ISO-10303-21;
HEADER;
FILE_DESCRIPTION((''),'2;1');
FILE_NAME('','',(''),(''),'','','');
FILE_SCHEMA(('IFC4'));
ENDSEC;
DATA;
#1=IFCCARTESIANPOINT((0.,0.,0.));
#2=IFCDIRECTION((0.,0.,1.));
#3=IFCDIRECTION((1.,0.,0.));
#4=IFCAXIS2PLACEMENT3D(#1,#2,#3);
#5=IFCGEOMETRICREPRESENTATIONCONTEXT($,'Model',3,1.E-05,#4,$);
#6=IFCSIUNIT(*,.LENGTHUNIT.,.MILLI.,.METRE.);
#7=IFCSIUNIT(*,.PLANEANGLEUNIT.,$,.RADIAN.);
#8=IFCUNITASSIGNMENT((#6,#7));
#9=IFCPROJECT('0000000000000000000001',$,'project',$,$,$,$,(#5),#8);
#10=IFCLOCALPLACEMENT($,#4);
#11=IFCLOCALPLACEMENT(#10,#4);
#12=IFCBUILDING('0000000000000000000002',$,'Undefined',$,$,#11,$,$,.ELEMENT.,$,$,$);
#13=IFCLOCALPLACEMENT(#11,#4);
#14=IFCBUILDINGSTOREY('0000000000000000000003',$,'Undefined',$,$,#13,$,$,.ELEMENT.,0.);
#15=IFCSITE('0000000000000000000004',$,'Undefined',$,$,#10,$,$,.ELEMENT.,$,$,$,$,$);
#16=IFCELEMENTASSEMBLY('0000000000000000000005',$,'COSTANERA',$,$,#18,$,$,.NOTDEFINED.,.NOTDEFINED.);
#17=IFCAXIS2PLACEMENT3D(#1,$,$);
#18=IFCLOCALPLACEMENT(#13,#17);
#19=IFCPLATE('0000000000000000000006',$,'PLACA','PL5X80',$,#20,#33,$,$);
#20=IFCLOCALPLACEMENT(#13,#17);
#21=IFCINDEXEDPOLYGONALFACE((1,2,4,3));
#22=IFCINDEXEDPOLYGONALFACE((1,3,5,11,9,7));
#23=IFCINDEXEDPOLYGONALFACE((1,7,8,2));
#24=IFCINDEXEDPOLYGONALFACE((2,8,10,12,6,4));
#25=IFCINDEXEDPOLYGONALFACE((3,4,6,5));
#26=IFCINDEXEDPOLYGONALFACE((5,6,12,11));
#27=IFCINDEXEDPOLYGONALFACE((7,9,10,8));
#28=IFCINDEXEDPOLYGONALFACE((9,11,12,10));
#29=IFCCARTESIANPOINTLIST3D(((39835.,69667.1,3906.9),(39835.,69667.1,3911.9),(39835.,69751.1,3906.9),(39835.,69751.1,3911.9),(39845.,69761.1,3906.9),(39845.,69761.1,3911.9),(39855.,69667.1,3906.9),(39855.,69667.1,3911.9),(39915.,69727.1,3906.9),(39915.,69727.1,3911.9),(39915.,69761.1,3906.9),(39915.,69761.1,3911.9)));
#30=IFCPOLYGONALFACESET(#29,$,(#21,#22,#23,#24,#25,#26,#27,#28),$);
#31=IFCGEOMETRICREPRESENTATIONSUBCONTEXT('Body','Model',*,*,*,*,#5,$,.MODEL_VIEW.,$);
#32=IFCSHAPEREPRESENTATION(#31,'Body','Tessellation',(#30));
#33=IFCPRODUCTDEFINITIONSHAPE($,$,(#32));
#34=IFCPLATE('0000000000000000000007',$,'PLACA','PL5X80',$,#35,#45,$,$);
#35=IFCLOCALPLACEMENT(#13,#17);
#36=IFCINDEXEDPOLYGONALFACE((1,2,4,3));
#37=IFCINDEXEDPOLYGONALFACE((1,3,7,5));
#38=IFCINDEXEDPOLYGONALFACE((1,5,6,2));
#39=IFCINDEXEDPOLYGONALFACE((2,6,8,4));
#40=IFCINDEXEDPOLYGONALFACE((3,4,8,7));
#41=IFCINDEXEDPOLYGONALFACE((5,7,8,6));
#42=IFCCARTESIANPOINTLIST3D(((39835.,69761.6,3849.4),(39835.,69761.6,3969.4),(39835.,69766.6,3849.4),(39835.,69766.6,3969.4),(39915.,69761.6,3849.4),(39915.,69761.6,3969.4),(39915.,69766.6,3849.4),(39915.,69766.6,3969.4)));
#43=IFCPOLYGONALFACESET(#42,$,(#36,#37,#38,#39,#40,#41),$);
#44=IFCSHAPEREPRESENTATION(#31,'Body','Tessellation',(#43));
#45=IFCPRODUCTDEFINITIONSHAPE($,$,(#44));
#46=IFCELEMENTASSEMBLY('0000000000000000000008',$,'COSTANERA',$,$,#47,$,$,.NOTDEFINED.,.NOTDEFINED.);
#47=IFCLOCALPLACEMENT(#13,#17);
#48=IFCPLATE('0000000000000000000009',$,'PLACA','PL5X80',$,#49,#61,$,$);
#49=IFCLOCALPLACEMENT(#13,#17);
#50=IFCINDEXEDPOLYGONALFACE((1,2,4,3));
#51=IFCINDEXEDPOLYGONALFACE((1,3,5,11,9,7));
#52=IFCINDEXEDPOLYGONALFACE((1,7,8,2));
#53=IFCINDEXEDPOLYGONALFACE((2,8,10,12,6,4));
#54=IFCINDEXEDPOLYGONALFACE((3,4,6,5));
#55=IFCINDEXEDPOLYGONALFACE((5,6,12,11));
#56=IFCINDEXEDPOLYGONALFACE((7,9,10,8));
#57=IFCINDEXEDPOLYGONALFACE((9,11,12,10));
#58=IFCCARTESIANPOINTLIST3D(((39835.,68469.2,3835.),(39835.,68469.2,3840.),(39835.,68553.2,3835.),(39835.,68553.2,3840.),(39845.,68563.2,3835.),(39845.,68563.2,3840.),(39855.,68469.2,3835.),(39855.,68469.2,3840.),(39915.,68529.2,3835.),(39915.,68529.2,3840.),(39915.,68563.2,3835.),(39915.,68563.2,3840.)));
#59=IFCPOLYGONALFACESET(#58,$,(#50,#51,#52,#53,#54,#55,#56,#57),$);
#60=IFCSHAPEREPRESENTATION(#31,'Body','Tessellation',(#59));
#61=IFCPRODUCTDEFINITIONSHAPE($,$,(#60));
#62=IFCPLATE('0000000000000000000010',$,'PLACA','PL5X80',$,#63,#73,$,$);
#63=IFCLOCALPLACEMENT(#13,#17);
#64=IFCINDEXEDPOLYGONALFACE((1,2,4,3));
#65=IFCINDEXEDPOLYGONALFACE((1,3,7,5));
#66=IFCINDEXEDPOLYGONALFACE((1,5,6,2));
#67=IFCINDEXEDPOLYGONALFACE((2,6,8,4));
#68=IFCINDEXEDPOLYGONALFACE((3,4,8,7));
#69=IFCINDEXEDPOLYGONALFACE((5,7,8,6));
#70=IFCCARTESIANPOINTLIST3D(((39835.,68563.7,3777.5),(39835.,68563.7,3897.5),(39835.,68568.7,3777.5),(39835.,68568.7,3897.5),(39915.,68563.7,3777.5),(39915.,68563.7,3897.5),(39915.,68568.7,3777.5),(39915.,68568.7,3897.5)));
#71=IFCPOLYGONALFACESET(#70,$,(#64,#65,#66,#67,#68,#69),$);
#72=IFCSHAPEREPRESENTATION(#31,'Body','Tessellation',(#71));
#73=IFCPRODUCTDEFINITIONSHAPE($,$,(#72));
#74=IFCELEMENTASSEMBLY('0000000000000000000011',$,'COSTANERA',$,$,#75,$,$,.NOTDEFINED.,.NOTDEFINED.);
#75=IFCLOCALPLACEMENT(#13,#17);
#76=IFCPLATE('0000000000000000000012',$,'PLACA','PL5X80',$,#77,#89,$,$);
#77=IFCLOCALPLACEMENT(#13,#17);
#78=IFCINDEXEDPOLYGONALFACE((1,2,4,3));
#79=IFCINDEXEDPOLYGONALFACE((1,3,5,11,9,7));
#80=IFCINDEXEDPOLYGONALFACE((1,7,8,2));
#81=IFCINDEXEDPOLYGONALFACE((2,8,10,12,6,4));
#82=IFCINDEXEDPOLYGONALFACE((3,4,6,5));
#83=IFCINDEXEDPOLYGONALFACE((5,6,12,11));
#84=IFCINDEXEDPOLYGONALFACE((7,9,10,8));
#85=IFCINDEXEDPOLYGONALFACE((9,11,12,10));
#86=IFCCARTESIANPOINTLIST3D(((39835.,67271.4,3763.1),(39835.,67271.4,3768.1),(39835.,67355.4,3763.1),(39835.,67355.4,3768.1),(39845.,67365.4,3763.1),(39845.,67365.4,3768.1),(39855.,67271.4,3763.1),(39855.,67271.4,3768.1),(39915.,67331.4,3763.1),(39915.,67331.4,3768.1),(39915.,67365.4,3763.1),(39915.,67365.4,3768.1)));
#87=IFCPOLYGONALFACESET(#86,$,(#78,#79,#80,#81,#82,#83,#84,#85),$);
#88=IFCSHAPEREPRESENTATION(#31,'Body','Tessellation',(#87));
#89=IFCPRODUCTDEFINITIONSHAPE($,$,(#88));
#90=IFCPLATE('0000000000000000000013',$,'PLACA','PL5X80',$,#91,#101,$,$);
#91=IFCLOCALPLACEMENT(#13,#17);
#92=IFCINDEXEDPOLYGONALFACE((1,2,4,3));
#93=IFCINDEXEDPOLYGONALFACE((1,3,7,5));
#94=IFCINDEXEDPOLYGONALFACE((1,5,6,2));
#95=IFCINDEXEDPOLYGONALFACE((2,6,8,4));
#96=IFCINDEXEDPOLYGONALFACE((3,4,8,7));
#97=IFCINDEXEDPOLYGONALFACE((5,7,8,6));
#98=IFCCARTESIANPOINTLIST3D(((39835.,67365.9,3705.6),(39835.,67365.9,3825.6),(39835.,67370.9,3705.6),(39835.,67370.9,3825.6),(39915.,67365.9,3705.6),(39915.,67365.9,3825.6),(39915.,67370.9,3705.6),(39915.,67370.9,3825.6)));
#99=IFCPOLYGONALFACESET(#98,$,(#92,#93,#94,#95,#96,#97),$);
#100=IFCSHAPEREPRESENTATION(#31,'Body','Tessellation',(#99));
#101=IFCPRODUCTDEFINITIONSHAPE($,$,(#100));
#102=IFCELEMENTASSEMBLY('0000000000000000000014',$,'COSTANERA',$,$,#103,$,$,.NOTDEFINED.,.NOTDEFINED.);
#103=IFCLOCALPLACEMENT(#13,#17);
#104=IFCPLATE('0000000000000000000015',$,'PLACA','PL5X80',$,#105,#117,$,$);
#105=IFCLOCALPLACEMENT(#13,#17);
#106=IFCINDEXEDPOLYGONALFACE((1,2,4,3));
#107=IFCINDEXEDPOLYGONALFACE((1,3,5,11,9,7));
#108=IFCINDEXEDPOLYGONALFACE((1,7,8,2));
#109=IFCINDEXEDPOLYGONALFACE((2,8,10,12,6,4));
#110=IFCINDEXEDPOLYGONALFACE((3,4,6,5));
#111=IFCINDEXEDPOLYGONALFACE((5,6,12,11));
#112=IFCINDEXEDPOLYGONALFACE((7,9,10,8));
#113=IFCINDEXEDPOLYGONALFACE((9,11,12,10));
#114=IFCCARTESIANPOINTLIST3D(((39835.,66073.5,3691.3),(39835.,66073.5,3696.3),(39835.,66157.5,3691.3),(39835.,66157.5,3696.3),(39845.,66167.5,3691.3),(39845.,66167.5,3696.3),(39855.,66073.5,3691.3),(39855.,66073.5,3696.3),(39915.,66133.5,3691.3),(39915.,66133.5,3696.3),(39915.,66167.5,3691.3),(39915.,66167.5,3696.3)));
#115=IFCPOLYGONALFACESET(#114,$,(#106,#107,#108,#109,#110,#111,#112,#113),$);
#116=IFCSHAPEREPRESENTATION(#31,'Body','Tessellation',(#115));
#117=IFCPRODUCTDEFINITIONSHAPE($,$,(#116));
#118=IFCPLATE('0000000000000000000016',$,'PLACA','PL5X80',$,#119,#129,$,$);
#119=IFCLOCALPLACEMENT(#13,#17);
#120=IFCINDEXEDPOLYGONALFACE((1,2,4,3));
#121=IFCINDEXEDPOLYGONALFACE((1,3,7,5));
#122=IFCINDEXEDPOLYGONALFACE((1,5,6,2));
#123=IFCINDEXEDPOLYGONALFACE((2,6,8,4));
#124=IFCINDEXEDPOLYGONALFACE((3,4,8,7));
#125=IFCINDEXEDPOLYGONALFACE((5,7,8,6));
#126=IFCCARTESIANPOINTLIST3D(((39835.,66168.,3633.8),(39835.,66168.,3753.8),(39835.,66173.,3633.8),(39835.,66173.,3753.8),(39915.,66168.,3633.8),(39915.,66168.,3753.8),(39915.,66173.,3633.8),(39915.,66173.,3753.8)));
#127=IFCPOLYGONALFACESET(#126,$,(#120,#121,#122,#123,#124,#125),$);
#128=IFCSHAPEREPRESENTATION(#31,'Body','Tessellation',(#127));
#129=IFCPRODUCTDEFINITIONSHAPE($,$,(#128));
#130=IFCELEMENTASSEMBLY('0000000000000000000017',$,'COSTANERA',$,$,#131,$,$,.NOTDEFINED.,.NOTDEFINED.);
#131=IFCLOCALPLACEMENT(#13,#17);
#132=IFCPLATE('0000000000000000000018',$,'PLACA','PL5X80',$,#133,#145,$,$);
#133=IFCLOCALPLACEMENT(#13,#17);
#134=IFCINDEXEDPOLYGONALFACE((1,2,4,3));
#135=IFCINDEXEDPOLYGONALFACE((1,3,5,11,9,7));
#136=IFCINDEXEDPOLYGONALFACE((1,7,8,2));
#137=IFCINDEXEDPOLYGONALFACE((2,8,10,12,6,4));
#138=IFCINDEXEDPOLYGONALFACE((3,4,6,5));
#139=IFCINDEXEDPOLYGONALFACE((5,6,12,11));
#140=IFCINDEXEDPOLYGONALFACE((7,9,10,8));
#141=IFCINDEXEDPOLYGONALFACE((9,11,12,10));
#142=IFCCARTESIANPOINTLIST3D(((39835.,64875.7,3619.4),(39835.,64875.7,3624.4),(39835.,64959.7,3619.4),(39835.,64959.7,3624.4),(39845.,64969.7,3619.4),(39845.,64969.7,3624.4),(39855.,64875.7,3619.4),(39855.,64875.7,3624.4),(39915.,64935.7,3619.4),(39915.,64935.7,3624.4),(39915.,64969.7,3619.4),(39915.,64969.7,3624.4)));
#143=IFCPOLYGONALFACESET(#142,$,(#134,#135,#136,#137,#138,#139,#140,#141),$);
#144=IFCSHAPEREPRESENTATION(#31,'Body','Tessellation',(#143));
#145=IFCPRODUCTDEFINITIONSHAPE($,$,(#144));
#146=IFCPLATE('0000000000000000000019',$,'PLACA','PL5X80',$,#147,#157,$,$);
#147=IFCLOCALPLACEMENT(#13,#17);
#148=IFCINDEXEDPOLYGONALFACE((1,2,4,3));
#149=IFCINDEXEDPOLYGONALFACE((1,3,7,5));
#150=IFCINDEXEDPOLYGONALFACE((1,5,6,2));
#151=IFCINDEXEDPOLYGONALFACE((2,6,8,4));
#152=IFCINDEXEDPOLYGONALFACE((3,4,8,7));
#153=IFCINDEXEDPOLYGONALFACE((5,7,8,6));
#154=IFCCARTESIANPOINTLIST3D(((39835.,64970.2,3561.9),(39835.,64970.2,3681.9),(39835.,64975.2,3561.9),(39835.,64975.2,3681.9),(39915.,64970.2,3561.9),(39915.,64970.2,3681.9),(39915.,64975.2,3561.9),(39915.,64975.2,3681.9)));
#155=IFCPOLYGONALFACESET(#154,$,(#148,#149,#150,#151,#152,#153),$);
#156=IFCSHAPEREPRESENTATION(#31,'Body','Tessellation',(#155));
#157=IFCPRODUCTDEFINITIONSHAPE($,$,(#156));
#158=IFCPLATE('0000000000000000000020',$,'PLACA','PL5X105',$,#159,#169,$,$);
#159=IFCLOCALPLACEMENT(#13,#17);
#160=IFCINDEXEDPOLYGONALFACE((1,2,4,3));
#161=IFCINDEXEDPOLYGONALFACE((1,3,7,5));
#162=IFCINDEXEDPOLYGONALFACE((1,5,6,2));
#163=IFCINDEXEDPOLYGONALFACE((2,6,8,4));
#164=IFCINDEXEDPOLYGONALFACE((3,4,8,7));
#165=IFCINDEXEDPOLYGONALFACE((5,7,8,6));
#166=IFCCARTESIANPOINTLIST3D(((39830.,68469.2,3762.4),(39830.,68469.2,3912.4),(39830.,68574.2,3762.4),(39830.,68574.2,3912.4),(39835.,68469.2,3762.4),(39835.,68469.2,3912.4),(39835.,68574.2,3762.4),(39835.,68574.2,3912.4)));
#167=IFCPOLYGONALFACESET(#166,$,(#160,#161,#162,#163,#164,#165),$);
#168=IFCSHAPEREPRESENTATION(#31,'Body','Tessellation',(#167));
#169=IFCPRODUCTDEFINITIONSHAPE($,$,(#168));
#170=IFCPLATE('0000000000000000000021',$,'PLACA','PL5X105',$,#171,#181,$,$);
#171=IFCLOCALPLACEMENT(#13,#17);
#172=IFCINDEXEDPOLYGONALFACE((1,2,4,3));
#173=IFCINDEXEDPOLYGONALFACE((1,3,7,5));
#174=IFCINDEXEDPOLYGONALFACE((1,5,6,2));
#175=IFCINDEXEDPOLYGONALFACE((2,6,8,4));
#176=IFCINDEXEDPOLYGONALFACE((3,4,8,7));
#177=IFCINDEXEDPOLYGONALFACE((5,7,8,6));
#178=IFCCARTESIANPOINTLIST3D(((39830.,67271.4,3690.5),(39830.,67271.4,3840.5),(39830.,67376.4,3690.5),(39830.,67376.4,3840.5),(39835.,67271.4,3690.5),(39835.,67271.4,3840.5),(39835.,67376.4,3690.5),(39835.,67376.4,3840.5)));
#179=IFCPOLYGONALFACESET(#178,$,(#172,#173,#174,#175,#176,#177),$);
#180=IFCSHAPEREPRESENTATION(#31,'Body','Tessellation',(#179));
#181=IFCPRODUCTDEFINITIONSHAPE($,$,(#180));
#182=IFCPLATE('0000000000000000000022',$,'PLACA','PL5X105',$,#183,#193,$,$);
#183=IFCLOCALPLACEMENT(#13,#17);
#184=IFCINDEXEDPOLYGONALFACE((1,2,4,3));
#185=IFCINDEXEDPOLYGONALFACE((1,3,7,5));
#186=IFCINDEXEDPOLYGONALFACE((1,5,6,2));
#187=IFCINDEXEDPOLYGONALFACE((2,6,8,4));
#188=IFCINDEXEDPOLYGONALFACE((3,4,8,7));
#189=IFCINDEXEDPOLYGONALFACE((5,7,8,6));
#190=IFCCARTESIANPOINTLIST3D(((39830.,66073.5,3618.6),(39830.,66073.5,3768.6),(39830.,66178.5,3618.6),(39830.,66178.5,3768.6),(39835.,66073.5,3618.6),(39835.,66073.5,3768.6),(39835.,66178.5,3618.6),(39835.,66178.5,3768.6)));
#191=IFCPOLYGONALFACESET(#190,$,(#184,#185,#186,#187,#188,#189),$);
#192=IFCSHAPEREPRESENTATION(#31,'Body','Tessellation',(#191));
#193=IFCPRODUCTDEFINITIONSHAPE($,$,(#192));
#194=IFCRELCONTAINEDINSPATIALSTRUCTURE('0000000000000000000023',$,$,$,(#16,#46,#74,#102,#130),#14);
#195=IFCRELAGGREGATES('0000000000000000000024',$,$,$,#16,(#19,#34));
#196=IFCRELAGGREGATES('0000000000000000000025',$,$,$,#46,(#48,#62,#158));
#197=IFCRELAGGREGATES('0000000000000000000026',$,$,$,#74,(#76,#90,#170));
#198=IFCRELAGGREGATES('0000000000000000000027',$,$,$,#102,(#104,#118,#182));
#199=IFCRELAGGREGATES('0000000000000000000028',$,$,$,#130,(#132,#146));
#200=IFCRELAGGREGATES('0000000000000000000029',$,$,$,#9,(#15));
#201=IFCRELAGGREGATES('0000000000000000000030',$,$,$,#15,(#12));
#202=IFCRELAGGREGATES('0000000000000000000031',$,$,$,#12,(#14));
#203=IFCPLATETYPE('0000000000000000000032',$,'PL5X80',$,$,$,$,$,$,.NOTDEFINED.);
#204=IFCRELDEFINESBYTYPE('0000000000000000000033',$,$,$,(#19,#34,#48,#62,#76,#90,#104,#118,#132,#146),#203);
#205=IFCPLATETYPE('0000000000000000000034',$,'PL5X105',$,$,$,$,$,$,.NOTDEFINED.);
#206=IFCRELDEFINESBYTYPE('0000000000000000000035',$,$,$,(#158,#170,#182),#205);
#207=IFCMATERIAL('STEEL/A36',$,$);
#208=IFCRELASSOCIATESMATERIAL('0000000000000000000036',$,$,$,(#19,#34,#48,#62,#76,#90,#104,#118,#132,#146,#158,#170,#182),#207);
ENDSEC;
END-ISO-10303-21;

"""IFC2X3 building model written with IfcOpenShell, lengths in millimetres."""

from ifc_helpers import new_model, si_unit, frame, origin_with_axes, place, context, subcontext, project, spatial, polyline, outline, extrude, material, type_object, element, aggregate, save


model = new_model("IFC2X3")

# Units and contexts
model_context = context("Model", 3, precision=1e-05, world=origin_with_axes())
body_context = subcontext(model_context, "Body", "Model", "MODEL_VIEW")
ifc_project = project(units=[si_unit("LENGTHUNIT", "METRE", prefix="MILLI"), si_unit("PLANEANGLEUNIT", "RADIAN")], contexts=[model_context])

# Site, building, storey
site_placement = place(None, origin_with_axes())
site = spatial("IfcSite", under=ifc_project, at=site_placement, Name="Undefined", CompositionType="ELEMENT")
building_placement = place(site_placement, origin_with_axes())
building = spatial("IfcBuilding", under=site, at=building_placement, Name="Undefined", CompositionType="ELEMENT")
storey_placement = place(building_placement, origin_with_axes())
storey = spatial("IfcBuildingStorey", under=building, at=storey_placement, Name="Undefined", CompositionType="ELEMENT", Elevation=0.0)

# Shared definitions
ifc_material_1 = material(Name="STEEL/A36")

# Element assemblies, plates
assembly_1_placement = place(storey_placement, origin_with_axes())
assembly_1 = element("IfcElementAssembly", 1, at=assembly_1_placement, inside=storey, Name="COSTANERA", AssemblyPlace="NOTDEFINED", PredefinedType="NOTDEFINED")
plate_type_1 = type_object("IfcPlateType", Name="PL5X80", PredefinedType="NOTDEFINED")
plate_1_placement = place(assembly_1_placement, frame((39915.0, 69761.1, 3909.4), z_axis=(0.0, 0.0, 1.0), x_axis=(-1.0, 0.0, 0.0)))
plate_1 = element("IfcPlate", 2, at=plate_1_placement, type_object=plate_type_1, material=ifc_material_1, Name="PLACA", Description="PL5X80", context=body_context, shape_type="SweptSolid", body=[
    extrude(outline(polyline([(0.0, 0.0), (70.0, 0.0), (80.0, 10.0), (80.0, 94.0), (60.0, 94.0), (0.0, 34.0), (0.0, 0.0)])), frame((0.0, 0.0, -2.5), z_axis=(0.0, 0.0, 1.0), x_axis=(1.0, 0.0, 0.0)), (0.0, 0.0, 1.0), 5.0),
])
plate_2_placement = place(assembly_1_placement, frame((39915.0, 69764.1, 3969.4), z_axis=(0.0, -1.0, 0.0), x_axis=(-1.0, 0.0, 0.0)))
plate_2 = element("IfcPlate", 3, at=plate_2_placement, type_object=plate_type_1, material=ifc_material_1, Name="PLACA", Description="PL5X80", context=body_context, shape_type="SweptSolid", body=[
    extrude(outline(polyline([(0.0, 0.0), (80.0, 0.0), (80.0, 120.0), (0.0, 120.0), (0.0, 0.0)])), frame((0.0, 0.0, -2.5), z_axis=(0.0, 0.0, 1.0), x_axis=(1.0, 0.0, 0.0)), (0.0, 0.0, 1.0), 5.0),
])
assembly_2_placement = place(storey_placement, origin_with_axes())
assembly_2 = element("IfcElementAssembly", 4, at=assembly_2_placement, inside=storey, Name="COSTANERA", AssemblyPlace="NOTDEFINED", PredefinedType="NOTDEFINED")
plate_3_placement = place(assembly_2_placement, frame((39915.0, 68563.2, 3837.5), z_axis=(0.0, 0.0, 1.0), x_axis=(-1.0, 0.0, 0.0)))
plate_3 = element("IfcPlate", 5, at=plate_3_placement, type_object=plate_type_1, material=ifc_material_1, Name="PLACA", Description="PL5X80", context=body_context, shape_type="SweptSolid", body=[
    extrude(outline(polyline([(0.0, 0.0), (70.0, 0.0), (80.0, 10.0), (80.0, 94.0), (60.0, 94.0), (0.0, 34.0), (0.0, 0.0)])), frame((0.0, 0.0, -2.5), z_axis=(0.0, 0.0, 1.0), x_axis=(1.0, 0.0, 0.0)), (0.0, 0.0, 1.0), 5.0),
])
plate_4_placement = place(assembly_2_placement, frame((39915.0, 68566.2, 3897.5), z_axis=(0.0, -1.0, 0.0), x_axis=(-1.0, 0.0, 0.0)))
plate_4 = element("IfcPlate", 6, at=plate_4_placement, type_object=plate_type_1, material=ifc_material_1, Name="PLACA", Description="PL5X80", context=body_context, shape_type="SweptSolid", body=[
    extrude(outline(polyline([(0.0, 0.0), (80.0, 0.0), (80.0, 120.0), (0.0, 120.0), (0.0, 0.0)])), frame((0.0, 0.0, -2.5), z_axis=(0.0, 0.0, 1.0), x_axis=(1.0, 0.0, 0.0)), (0.0, 0.0, 1.0), 5.0),
])
assembly_3_placement = place(storey_placement, origin_with_axes())
assembly_3 = element("IfcElementAssembly", 7, at=assembly_3_placement, inside=storey, Name="COSTANERA", AssemblyPlace="NOTDEFINED", PredefinedType="NOTDEFINED")
plate_5_placement = place(assembly_3_placement, frame((39915.0, 67365.4, 3765.6), z_axis=(0.0, 0.0, 1.0), x_axis=(-1.0, 0.0, 0.0)))
plate_5 = element("IfcPlate", 8, at=plate_5_placement, type_object=plate_type_1, material=ifc_material_1, Name="PLACA", Description="PL5X80", context=body_context, shape_type="SweptSolid", body=[
    extrude(outline(polyline([(0.0, 0.0), (70.0, 0.0), (80.0, 10.0), (80.0, 94.0), (60.0, 94.0), (0.0, 34.0), (0.0, 0.0)])), frame((0.0, 0.0, -2.5), z_axis=(0.0, 0.0, 1.0), x_axis=(1.0, 0.0, 0.0)), (0.0, 0.0, 1.0), 5.0),
])
plate_6_placement = place(assembly_3_placement, frame((39915.0, 67368.4, 3825.6), z_axis=(0.0, -1.0, 0.0), x_axis=(-1.0, 0.0, 0.0)))
plate_6 = element("IfcPlate", 9, at=plate_6_placement, type_object=plate_type_1, material=ifc_material_1, Name="PLACA", Description="PL5X80", context=body_context, shape_type="SweptSolid", body=[
    extrude(outline(polyline([(0.0, 0.0), (80.0, 0.0), (80.0, 120.0), (0.0, 120.0), (0.0, 0.0)])), frame((0.0, 0.0, -2.5), z_axis=(0.0, 0.0, 1.0), x_axis=(1.0, 0.0, 0.0)), (0.0, 0.0, 1.0), 5.0),
])
assembly_4_placement = place(storey_placement, origin_with_axes())
assembly_4 = element("IfcElementAssembly", 10, at=assembly_4_placement, inside=storey, Name="COSTANERA", AssemblyPlace="NOTDEFINED", PredefinedType="NOTDEFINED")
plate_7_placement = place(assembly_4_placement, frame((39915.0, 66167.5, 3693.8), z_axis=(0.0, 0.0, 1.0), x_axis=(-1.0, 0.0, 0.0)))
plate_7 = element("IfcPlate", 11, at=plate_7_placement, type_object=plate_type_1, material=ifc_material_1, Name="PLACA", Description="PL5X80", context=body_context, shape_type="SweptSolid", body=[
    extrude(outline(polyline([(0.0, 0.0), (70.0, 0.0), (80.0, 10.0), (80.0, 94.0), (60.0, 94.0), (0.0, 34.0), (0.0, 0.0)])), frame((0.0, 0.0, -2.5), z_axis=(0.0, 0.0, 1.0), x_axis=(1.0, 0.0, 0.0)), (0.0, 0.0, 1.0), 5.0),
])
plate_8_placement = place(assembly_4_placement, frame((39915.0, 66170.5, 3753.8), z_axis=(0.0, -1.0, 0.0), x_axis=(-1.0, 0.0, 0.0)))
plate_8 = element("IfcPlate", 12, at=plate_8_placement, type_object=plate_type_1, material=ifc_material_1, Name="PLACA", Description="PL5X80", context=body_context, shape_type="SweptSolid", body=[
    extrude(outline(polyline([(0.0, 0.0), (80.0, 0.0), (80.0, 120.0), (0.0, 120.0), (0.0, 0.0)])), frame((0.0, 0.0, -2.5), z_axis=(0.0, 0.0, 1.0), x_axis=(1.0, 0.0, 0.0)), (0.0, 0.0, 1.0), 5.0),
])
assembly_5_placement = place(storey_placement, origin_with_axes())
assembly_5 = element("IfcElementAssembly", 13, at=assembly_5_placement, inside=storey, Name="COSTANERA", AssemblyPlace="NOTDEFINED", PredefinedType="NOTDEFINED")
plate_9_placement = place(assembly_5_placement, frame((39915.0, 64969.7, 3621.9), z_axis=(0.0, 0.0, 1.0), x_axis=(-1.0, 0.0, 0.0)))
plate_9 = element("IfcPlate", 14, at=plate_9_placement, type_object=plate_type_1, material=ifc_material_1, Name="PLACA", Description="PL5X80", context=body_context, shape_type="SweptSolid", body=[
    extrude(outline(polyline([(0.0, 0.0), (70.0, 0.0), (80.0, 10.0), (80.0, 94.0), (60.0, 94.0), (0.0, 34.0), (0.0, 0.0)])), frame((0.0, 0.0, -2.5), z_axis=(0.0, 0.0, 1.0), x_axis=(1.0, 0.0, 0.0)), (0.0, 0.0, 1.0), 5.0),
])
plate_10_placement = place(assembly_5_placement, frame((39915.0, 64972.7, 3681.9), z_axis=(0.0, -1.0, 0.0), x_axis=(-1.0, 0.0, 0.0)))
plate_10 = element("IfcPlate", 15, at=plate_10_placement, type_object=plate_type_1, material=ifc_material_1, Name="PLACA", Description="PL5X80", context=body_context, shape_type="SweptSolid", body=[
    extrude(outline(polyline([(0.0, 0.0), (80.0, 0.0), (80.0, 120.0), (0.0, 120.0), (0.0, 0.0)])), frame((0.0, 0.0, -2.5), z_axis=(0.0, 0.0, 1.0), x_axis=(1.0, 0.0, 0.0)), (0.0, 0.0, 1.0), 5.0),
])

# Plates
plate_type_2 = type_object("IfcPlateType", Name="PL5X105", PredefinedType="NOTDEFINED")
plate_11_placement = place(assembly_2_placement, frame((39832.5, 68574.2, 3762.4), z_axis=(-1.0, 0.0, 0.0), x_axis=(0.0, -1.0, 0.0)))
plate_11 = element("IfcPlate", 16, at=plate_11_placement, type_object=plate_type_2, material=ifc_material_1, Name="PLACA", Description="PL5X105", context=body_context, shape_type="SweptSolid", body=[
    extrude(outline(polyline([(0.0, 0.0), (105.0, 0.0), (105.0, 150.0), (0.0, 150.0), (0.0, 0.0)])), frame((0.0, 0.0, -2.5), z_axis=(0.0, 0.0, 1.0), x_axis=(1.0, 0.0, 0.0)), (0.0, 0.0, 1.0), 5.0),
])
plate_12_placement = place(assembly_3_placement, frame((39832.5, 67376.4, 3690.5), z_axis=(-1.0, 0.0, 0.0), x_axis=(0.0, -1.0, 0.0)))
plate_12 = element("IfcPlate", 17, at=plate_12_placement, type_object=plate_type_2, material=ifc_material_1, Name="PLACA", Description="PL5X105", context=body_context, shape_type="SweptSolid", body=[
    extrude(outline(polyline([(0.0, 0.0), (105.0, 0.0), (105.0, 150.0), (0.0, 150.0), (0.0, 0.0)])), frame((0.0, 0.0, -2.5), z_axis=(0.0, 0.0, 1.0), x_axis=(1.0, 0.0, 0.0)), (0.0, 0.0, 1.0), 5.0),
])
plate_13_placement = place(assembly_4_placement, frame((39832.5, 66178.5, 3618.6), z_axis=(-1.0, 0.0, 0.0), x_axis=(0.0, -1.0, 0.0)))
plate_13 = element("IfcPlate", 18, at=plate_13_placement, type_object=plate_type_2, material=ifc_material_1, Name="PLACA", Description="PL5X105", context=body_context, shape_type="SweptSolid", body=[
    extrude(outline(polyline([(0.0, 0.0), (105.0, 0.0), (105.0, 150.0), (0.0, 150.0), (0.0, 0.0)])), frame((0.0, 0.0, -2.5), z_axis=(0.0, 0.0, 1.0), x_axis=(1.0, 0.0, 0.0)), (0.0, 0.0, 1.0), 5.0),
])

aggregate(assembly_1, [plate_1, plate_2])
aggregate(assembly_2, [plate_3, plate_4, plate_11])
aggregate(assembly_3, [plate_5, plate_6, plate_12])
aggregate(assembly_4, [plate_7, plate_8, plate_13])
aggregate(assembly_5, [plate_9, plate_10])

save(model, "model.ifc")
